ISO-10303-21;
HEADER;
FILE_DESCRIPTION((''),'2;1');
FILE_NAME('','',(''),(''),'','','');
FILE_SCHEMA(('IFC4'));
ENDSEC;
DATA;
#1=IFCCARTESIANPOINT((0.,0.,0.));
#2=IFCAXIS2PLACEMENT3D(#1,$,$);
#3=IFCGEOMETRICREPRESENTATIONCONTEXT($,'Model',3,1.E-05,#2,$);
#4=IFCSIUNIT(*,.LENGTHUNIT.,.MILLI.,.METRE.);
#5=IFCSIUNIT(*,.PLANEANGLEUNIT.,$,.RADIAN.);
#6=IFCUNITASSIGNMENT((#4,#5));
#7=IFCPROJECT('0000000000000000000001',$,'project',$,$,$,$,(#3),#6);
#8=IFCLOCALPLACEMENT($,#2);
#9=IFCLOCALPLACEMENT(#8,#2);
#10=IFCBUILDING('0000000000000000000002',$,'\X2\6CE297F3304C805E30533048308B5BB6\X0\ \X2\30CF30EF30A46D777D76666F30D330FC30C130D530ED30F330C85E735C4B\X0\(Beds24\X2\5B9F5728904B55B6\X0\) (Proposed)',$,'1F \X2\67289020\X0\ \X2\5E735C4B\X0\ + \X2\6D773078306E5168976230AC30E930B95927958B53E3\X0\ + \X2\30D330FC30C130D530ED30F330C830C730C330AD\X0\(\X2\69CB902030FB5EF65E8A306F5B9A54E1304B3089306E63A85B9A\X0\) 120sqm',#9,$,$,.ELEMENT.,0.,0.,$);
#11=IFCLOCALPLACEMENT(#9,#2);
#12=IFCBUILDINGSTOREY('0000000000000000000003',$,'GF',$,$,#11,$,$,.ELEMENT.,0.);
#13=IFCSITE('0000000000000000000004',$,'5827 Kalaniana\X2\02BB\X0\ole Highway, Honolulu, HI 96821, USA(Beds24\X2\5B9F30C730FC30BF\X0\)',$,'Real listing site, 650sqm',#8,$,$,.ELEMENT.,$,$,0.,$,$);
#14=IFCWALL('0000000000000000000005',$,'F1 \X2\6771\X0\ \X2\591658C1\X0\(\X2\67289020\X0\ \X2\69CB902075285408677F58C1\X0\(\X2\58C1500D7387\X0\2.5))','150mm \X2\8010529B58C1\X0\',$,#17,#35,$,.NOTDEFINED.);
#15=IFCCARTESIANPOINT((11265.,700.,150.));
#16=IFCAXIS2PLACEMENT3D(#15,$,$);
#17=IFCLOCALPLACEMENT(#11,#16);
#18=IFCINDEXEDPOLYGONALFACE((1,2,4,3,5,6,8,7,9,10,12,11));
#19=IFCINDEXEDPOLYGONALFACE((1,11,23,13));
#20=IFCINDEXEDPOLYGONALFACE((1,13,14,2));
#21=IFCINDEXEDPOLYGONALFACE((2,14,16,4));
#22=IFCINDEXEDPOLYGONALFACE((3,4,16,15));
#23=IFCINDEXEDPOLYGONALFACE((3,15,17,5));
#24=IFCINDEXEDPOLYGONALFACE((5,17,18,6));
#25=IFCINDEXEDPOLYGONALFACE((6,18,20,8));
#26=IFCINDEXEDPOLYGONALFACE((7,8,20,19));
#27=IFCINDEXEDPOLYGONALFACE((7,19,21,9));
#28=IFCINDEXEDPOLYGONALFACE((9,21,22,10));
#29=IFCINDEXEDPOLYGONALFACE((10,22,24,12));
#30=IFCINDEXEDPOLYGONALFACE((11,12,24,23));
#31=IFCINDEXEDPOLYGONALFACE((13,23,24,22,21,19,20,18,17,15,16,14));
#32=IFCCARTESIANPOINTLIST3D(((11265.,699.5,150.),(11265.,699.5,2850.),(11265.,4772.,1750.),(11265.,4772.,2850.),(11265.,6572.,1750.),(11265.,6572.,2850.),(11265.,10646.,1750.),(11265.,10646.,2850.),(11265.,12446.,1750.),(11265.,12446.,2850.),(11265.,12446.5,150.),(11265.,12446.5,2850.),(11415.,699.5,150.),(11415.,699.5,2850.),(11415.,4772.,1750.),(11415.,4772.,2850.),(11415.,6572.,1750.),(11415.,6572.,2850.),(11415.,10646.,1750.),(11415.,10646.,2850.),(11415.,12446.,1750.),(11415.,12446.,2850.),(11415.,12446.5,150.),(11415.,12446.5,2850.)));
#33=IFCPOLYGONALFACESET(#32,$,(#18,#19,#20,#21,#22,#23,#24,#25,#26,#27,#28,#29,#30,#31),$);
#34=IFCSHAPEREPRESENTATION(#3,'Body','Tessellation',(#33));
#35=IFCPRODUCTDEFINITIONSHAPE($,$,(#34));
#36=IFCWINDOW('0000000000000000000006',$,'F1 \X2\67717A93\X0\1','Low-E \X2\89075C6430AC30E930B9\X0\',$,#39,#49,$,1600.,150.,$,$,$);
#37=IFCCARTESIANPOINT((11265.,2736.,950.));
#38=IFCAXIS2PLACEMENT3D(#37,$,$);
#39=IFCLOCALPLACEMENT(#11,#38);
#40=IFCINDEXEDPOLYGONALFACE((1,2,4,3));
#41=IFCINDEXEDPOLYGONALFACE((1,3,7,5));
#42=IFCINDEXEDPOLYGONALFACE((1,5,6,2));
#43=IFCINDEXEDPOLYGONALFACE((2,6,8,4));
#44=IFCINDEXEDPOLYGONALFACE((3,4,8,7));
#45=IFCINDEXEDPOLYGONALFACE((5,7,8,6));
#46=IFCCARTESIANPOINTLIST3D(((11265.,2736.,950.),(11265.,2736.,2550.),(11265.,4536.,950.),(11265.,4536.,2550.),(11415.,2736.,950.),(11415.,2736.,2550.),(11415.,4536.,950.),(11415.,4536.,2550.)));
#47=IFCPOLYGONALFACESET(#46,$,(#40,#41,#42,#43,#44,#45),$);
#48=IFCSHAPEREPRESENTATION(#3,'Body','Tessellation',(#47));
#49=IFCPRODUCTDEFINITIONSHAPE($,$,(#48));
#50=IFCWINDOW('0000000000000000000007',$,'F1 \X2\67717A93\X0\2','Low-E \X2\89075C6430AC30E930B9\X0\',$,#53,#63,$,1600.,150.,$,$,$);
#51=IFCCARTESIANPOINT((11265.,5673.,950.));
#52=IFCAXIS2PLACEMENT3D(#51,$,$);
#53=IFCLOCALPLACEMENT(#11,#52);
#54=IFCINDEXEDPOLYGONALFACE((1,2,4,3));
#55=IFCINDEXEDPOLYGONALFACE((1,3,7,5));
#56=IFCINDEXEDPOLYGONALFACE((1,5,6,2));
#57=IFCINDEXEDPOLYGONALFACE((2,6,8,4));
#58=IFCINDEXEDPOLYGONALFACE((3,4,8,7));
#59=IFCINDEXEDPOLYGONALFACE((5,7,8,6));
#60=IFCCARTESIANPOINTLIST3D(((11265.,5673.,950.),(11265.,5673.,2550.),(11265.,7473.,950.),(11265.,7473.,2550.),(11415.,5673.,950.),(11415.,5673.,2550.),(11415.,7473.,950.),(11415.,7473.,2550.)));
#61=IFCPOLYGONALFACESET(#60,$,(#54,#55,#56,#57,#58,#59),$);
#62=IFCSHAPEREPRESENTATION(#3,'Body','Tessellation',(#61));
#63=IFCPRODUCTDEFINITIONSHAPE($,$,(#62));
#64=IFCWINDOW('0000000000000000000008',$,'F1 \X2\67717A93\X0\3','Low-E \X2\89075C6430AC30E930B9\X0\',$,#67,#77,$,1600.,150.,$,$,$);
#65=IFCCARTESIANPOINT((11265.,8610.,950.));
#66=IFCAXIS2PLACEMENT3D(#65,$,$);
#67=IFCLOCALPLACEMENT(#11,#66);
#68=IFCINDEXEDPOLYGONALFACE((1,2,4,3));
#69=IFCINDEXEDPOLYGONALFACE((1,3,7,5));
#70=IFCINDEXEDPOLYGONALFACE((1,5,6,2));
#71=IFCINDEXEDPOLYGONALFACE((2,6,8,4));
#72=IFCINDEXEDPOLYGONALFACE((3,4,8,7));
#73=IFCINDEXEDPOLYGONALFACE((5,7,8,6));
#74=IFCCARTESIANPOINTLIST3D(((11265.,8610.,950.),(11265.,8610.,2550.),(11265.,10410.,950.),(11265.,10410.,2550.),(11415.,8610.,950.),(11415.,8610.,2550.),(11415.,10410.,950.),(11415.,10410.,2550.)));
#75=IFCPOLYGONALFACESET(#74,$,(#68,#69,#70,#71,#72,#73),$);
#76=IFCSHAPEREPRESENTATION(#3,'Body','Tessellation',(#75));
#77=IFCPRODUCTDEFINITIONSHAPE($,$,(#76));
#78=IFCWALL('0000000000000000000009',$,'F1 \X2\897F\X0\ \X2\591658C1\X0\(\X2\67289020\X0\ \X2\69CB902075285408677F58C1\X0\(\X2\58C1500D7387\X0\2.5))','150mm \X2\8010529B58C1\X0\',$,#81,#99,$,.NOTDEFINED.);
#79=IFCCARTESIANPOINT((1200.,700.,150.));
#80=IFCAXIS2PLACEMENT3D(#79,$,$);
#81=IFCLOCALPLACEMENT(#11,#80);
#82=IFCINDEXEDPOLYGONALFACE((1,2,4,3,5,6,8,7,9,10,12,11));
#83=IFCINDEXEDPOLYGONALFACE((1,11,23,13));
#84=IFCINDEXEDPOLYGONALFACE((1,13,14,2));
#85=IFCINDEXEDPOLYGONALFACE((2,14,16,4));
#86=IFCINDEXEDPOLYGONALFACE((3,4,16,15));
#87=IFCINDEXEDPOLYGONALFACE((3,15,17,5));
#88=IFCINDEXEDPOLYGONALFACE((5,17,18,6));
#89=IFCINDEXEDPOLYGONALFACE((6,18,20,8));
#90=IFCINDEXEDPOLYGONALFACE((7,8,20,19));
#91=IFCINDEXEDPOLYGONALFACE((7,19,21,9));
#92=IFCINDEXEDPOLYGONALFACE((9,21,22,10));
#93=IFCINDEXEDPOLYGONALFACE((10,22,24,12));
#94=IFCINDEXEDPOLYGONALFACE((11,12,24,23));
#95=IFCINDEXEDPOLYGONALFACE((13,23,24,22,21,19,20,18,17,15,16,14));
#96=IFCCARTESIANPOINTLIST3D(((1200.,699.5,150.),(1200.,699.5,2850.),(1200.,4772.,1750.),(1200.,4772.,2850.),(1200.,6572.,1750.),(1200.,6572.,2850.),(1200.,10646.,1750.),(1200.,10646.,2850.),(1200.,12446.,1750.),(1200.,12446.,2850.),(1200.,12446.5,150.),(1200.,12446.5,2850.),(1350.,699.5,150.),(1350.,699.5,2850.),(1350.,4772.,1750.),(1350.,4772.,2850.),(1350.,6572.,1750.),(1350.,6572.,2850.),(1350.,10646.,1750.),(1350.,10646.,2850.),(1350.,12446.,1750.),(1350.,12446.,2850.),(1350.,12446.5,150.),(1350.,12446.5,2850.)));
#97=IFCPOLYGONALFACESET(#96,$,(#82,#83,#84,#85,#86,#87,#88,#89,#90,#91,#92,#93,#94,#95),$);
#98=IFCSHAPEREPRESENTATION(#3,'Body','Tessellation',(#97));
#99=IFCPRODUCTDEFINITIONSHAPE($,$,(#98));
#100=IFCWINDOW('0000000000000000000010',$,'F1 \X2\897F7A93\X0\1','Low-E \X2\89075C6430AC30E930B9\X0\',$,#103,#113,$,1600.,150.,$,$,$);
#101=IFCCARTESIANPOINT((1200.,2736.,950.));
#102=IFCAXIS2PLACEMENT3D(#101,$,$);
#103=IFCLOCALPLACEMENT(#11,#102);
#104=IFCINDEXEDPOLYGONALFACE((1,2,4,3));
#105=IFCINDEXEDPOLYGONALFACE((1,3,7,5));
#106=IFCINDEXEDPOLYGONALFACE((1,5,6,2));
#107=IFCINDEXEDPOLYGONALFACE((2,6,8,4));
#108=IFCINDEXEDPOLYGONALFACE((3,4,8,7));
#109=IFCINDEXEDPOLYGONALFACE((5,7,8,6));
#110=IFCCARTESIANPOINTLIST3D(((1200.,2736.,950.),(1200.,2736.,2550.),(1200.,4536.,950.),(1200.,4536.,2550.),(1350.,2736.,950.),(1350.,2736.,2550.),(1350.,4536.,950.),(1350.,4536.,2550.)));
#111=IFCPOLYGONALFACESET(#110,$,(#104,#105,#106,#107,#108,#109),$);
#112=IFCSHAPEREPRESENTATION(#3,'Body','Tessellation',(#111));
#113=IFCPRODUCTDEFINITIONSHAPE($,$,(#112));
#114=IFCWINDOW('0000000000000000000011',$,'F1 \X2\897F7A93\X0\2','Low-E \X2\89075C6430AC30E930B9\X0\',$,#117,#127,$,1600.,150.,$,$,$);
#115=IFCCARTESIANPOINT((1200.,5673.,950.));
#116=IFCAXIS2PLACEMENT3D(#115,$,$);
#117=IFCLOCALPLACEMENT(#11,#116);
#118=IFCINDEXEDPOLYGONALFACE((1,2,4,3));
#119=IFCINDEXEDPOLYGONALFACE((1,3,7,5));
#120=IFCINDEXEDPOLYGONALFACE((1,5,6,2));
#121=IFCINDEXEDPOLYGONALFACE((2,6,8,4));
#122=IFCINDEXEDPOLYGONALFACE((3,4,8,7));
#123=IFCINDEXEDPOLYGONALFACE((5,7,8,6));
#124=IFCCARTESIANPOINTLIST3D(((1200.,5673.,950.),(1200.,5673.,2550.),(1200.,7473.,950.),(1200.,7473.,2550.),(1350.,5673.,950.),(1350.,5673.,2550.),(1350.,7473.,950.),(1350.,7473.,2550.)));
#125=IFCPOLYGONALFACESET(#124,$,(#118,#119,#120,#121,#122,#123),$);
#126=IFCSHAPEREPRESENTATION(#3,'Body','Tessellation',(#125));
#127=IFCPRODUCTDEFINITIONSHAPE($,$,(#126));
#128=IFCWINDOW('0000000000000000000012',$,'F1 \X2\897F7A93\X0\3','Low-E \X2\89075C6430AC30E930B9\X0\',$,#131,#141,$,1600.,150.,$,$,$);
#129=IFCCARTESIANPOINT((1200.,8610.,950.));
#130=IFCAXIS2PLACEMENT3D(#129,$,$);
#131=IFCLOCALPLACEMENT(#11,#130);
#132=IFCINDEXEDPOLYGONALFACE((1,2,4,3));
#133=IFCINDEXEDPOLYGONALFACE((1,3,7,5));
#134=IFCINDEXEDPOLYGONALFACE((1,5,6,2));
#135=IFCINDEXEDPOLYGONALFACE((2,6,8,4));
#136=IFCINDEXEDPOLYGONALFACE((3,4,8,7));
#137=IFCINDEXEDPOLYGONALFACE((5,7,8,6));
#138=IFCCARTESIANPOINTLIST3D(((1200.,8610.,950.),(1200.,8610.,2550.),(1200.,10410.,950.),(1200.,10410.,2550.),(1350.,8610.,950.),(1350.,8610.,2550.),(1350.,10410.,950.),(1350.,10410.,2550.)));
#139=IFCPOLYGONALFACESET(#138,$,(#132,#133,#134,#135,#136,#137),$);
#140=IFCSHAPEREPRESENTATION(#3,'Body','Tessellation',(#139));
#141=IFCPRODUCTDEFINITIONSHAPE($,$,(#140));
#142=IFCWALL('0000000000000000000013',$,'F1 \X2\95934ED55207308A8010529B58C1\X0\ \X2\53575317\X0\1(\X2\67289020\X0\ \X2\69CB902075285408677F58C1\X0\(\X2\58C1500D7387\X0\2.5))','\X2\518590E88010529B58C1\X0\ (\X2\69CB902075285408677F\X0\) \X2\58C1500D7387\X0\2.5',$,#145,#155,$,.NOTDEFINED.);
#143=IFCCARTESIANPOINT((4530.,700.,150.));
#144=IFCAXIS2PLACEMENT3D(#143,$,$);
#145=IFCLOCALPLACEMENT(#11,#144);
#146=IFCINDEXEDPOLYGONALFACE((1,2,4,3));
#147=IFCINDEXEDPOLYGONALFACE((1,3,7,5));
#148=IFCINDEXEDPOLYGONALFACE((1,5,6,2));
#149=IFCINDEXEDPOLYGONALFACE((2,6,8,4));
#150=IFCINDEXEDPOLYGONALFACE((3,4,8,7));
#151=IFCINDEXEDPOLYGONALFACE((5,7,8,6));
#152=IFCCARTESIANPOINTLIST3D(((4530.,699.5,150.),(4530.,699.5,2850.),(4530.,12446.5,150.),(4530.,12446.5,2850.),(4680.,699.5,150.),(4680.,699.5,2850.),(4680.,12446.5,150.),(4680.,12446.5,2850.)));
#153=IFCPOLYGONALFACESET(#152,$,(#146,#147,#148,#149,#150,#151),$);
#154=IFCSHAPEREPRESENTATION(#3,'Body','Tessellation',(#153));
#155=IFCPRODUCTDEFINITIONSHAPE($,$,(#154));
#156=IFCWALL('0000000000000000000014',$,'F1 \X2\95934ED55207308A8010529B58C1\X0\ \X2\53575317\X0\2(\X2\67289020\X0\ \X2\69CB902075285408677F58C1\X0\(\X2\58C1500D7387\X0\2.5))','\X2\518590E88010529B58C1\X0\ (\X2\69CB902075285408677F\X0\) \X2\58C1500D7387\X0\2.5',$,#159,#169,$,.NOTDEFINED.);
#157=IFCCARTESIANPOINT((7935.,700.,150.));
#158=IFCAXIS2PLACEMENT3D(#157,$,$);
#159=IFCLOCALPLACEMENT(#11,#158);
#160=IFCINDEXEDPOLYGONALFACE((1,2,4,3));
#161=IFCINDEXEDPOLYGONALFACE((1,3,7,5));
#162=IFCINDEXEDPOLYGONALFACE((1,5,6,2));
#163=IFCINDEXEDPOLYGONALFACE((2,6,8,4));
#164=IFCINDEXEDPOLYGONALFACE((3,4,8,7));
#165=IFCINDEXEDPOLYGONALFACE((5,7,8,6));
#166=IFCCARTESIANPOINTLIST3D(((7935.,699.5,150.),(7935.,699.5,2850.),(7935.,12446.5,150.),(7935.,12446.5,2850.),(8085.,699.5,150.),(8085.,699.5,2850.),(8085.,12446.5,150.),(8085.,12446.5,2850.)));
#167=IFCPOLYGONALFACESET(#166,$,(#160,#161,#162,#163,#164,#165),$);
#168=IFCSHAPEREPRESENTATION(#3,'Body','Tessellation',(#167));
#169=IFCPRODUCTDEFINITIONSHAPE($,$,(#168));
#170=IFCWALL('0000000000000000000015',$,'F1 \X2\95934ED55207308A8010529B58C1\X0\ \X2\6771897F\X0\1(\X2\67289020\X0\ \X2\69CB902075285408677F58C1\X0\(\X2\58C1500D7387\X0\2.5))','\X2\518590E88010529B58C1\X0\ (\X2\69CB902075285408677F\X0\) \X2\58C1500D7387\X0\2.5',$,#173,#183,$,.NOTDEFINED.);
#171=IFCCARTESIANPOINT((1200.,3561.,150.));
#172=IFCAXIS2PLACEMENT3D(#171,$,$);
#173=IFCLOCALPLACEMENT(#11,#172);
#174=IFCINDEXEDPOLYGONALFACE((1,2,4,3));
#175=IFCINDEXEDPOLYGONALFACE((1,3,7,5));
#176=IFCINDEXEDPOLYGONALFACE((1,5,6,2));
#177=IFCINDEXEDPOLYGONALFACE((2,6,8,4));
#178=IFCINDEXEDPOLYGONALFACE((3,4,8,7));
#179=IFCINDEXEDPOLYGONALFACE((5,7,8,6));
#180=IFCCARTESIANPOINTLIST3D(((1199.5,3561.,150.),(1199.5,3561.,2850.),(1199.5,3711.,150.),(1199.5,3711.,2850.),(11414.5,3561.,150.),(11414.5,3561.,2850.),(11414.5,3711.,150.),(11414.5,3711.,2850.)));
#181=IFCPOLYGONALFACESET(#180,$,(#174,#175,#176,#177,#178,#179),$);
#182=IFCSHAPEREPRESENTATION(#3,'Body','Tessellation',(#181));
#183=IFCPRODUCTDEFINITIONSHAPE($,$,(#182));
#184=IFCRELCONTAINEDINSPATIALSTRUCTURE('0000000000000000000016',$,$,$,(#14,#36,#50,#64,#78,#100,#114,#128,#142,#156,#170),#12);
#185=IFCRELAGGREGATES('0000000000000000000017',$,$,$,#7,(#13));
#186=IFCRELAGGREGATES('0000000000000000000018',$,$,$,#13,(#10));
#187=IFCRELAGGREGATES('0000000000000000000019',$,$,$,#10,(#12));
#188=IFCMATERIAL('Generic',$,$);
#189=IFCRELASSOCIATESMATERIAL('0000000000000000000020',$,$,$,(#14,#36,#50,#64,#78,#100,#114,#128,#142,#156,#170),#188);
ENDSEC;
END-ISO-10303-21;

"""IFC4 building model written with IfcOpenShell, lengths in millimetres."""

from ifc_helpers import new_model, si_unit, frame, frame_2d, origin, place, context, project, spatial, rectangle, extrude, material, element, fill, save


model = new_model("IFC4")

# Units and contexts
model_context = context("Model", 3, precision=1e-05, world=origin())
ifc_project = project(units=[si_unit("LENGTHUNIT", "METRE", prefix="MILLI"), si_unit("PLANEANGLEUNIT", "RADIAN")], contexts=[model_context])

# Site, building, storey
site_placement = place(None, origin())
site = spatial("IfcSite", under=ifc_project, at=site_placement, Name="5827 Kalanianaʻole Highway, Honolulu, HI 96821, USA(Beds24実データ)", ObjectType="Real listing site, 650sqm", CompositionType="ELEMENT", RefElevation=0.0)
building_placement = place(site_placement, origin())
building = spatial("IfcBuilding", under=site, at=building_placement, Name="波音が聞こえる家 ハワイ海絶景ビーチフロント平屋(Beds24実在運営) (Proposed)", ObjectType="1F 木造 平屋 + 海への全面ガラス大開口 + ビーチフロントデッキ(構造・延床は定員からの推定) 120sqm", CompositionType="ELEMENT", ElevationOfRefHeight=0.0, ElevationOfTerrain=0.0)
storey_placement = place(building_placement, origin())
storey = spatial("IfcBuildingStorey", under=building, at=storey_placement, Name="GF", CompositionType="ELEMENT", Elevation=0.0)

# Shared definitions
ifc_material_1 = material(Name="Generic")

# Walls, openings, windows
wall_1_placement = place(storey_placement, frame((11265.0, 700.0, 150.0)))
wall_1 = element("IfcWall", 1, at=wall_1_placement, inside=storey, material=ifc_material_1, Name="F1 東 外壁(木造 構造用合板壁(壁倍率2.5))", Description="150mm 耐力壁", PredefinedType="NOTDEFINED", context=model_context, shape_type="SweptSolid", body=[
    extrude(rectangle(XDim=150.0, YDim=11747.0, at=frame_2d((75.0, 5873.0))), frame((11265.0, 700.0, 150.0)), (0.0, 0.0, 1.0), 2700.0),
])
opening_1_placement = place(storey_placement, frame((11265.0, 2736.0, 950.0)))
opening_1 = element("IfcOpeningElement", 2, at=opening_1_placement, cuts=wall_1, PredefinedType="NOTDEFINED", context=model_context, shape_type="SweptSolid", body=[
    extrude(rectangle(XDim=150.0, YDim=1800.0, at=frame_2d((75.0, 900.0))), frame((11265.0, 2736.0, 950.0)), (0.0, 0.0, 1.0), 1600.0),
])
opening_2_placement = place(storey_placement, frame((11265.0, 5673.0, 950.0)))
opening_2 = element("IfcOpeningElement", 3, at=opening_2_placement, cuts=wall_1, PredefinedType="NOTDEFINED", context=model_context, shape_type="SweptSolid", body=[
    extrude(rectangle(XDim=150.0, YDim=1800.0, at=frame_2d((75.0, 900.0))), frame((11265.0, 5673.0, 950.0)), (0.0, 0.0, 1.0), 1600.0),
])
opening_3_placement = place(storey_placement, frame((11265.0, 8610.0, 950.0)))
opening_3 = element("IfcOpeningElement", 4, at=opening_3_placement, cuts=wall_1, PredefinedType="NOTDEFINED", context=model_context, shape_type="SweptSolid", body=[
    extrude(rectangle(XDim=150.0, YDim=1800.0, at=frame_2d((75.0, 900.0))), frame((11265.0, 8610.0, 950.0)), (0.0, 0.0, 1.0), 1600.0),
])
window_1_placement = place(storey_placement, frame((11265.0, 2736.0, 950.0)))
window_1 = element("IfcWindow", 5, at=window_1_placement, inside=storey, material=ifc_material_1, Name="F1 東窓1", Description="Low-E 複層ガラス", OverallHeight=1600.0, OverallWidth=150.0, context=model_context, shape_type="SweptSolid", body=[
    extrude(rectangle(XDim=150.0, YDim=1800.0, at=frame_2d((75.0, 900.0))), frame((11265.0, 2736.0, 950.0)), (0.0, 0.0, 1.0), 1600.0),
])
fill(opening_1, window_1)
window_2_placement = place(storey_placement, frame((11265.0, 5673.0, 950.0)))
window_2 = element("IfcWindow", 6, at=window_2_placement, inside=storey, material=ifc_material_1, Name="F1 東窓2", Description="Low-E 複層ガラス", OverallHeight=1600.0, OverallWidth=150.0, context=model_context, shape_type="SweptSolid", body=[
    extrude(rectangle(XDim=150.0, YDim=1800.0, at=frame_2d((75.0, 900.0))), frame((11265.0, 5673.0, 950.0)), (0.0, 0.0, 1.0), 1600.0),
])
fill(opening_2, window_2)
window_3_placement = place(storey_placement, frame((11265.0, 8610.0, 950.0)))
window_3 = element("IfcWindow", 7, at=window_3_placement, inside=storey, material=ifc_material_1, Name="F1 東窓3", Description="Low-E 複層ガラス", OverallHeight=1600.0, OverallWidth=150.0, context=model_context, shape_type="SweptSolid", body=[
    extrude(rectangle(XDim=150.0, YDim=1800.0, at=frame_2d((75.0, 900.0))), frame((11265.0, 8610.0, 950.0)), (0.0, 0.0, 1.0), 1600.0),
])
fill(opening_3, window_3)
wall_2_placement = place(storey_placement, frame((1200.0, 700.0, 150.0)))
wall_2 = element("IfcWall", 8, at=wall_2_placement, inside=storey, material=ifc_material_1, Name="F1 西 外壁(木造 構造用合板壁(壁倍率2.5))", Description="150mm 耐力壁", PredefinedType="NOTDEFINED", context=model_context, shape_type="SweptSolid", body=[
    extrude(rectangle(XDim=150.0, YDim=11747.0, at=frame_2d((75.0, 5873.0))), frame((1200.0, 700.0, 150.0)), (0.0, 0.0, 1.0), 2700.0),
])
opening_4_placement = place(storey_placement, frame((1200.0, 2736.0, 950.0)))
opening_4 = element("IfcOpeningElement", 9, at=opening_4_placement, cuts=wall_2, PredefinedType="NOTDEFINED", context=model_context, shape_type="SweptSolid", body=[
    extrude(rectangle(XDim=150.0, YDim=1800.0, at=frame_2d((75.0, 900.0))), frame((1200.0, 2736.0, 950.0)), (0.0, 0.0, 1.0), 1600.0),
])
opening_5_placement = place(storey_placement, frame((1200.0, 5673.0, 950.0)))
opening_5 = element("IfcOpeningElement", 10, at=opening_5_placement, cuts=wall_2, PredefinedType="NOTDEFINED", context=model_context, shape_type="SweptSolid", body=[
    extrude(rectangle(XDim=150.0, YDim=1800.0, at=frame_2d((75.0, 900.0))), frame((1200.0, 5673.0, 950.0)), (0.0, 0.0, 1.0), 1600.0),
])
opening_6_placement = place(storey_placement, frame((1200.0, 8610.0, 950.0)))
opening_6 = element("IfcOpeningElement", 11, at=opening_6_placement, cuts=wall_2, PredefinedType="NOTDEFINED", context=model_context, shape_type="SweptSolid", body=[
    extrude(rectangle(XDim=150.0, YDim=1800.0, at=frame_2d((75.0, 900.0))), frame((1200.0, 8610.0, 950.0)), (0.0, 0.0, 1.0), 1600.0),
])
window_4_placement = place(storey_placement, frame((1200.0, 2736.0, 950.0)))
window_4 = element("IfcWindow", 12, at=window_4_placement, inside=storey, material=ifc_material_1, Name="F1 西窓1", Description="Low-E 複層ガラス", OverallHeight=1600.0, OverallWidth=150.0, context=model_context, shape_type="SweptSolid", body=[
    extrude(rectangle(XDim=150.0, YDim=1800.0, at=frame_2d((75.0, 900.0))), frame((1200.0, 2736.0, 950.0)), (0.0, 0.0, 1.0), 1600.0),
])
fill(opening_4, window_4)
window_5_placement = place(storey_placement, frame((1200.0, 5673.0, 950.0)))
window_5 = element("IfcWindow", 13, at=window_5_placement, inside=storey, material=ifc_material_1, Name="F1 西窓2", Description="Low-E 複層ガラス", OverallHeight=1600.0, OverallWidth=150.0, context=model_context, shape_type="SweptSolid", body=[
    extrude(rectangle(XDim=150.0, YDim=1800.0, at=frame_2d((75.0, 900.0))), frame((1200.0, 5673.0, 950.0)), (0.0, 0.0, 1.0), 1600.0),
])
fill(opening_5, window_5)
window_6_placement = place(storey_placement, frame((1200.0, 8610.0, 950.0)))
window_6 = element("IfcWindow", 14, at=window_6_placement, inside=storey, material=ifc_material_1, Name="F1 西窓3", Description="Low-E 複層ガラス", OverallHeight=1600.0, OverallWidth=150.0, context=model_context, shape_type="SweptSolid", body=[
    extrude(rectangle(XDim=150.0, YDim=1800.0, at=frame_2d((75.0, 900.0))), frame((1200.0, 8610.0, 950.0)), (0.0, 0.0, 1.0), 1600.0),
])
fill(opening_6, window_6)

# Walls
wall_3_placement = place(storey_placement, frame((4530.0, 700.0, 150.0)))
element("IfcWall", 15, at=wall_3_placement, inside=storey, material=ifc_material_1, Name="F1 間仕切り耐力壁 南北1(木造 構造用合板壁(壁倍率2.5))", Description="内部耐力壁 (構造用合板) 壁倍率2.5", PredefinedType="NOTDEFINED", context=model_context, shape_type="SweptSolid", body=[
    extrude(rectangle(XDim=150.0, YDim=11747.0, at=frame_2d((75.0, 5873.0))), frame((4530.0, 700.0, 150.0)), (0.0, 0.0, 1.0), 2700.0),
])
wall_4_placement = place(storey_placement, frame((7935.0, 700.0, 150.0)))
element("IfcWall", 16, at=wall_4_placement, inside=storey, material=ifc_material_1, Name="F1 間仕切り耐力壁 南北2(木造 構造用合板壁(壁倍率2.5))", Description="内部耐力壁 (構造用合板) 壁倍率2.5", PredefinedType="NOTDEFINED", context=model_context, shape_type="SweptSolid", body=[
    extrude(rectangle(XDim=150.0, YDim=11747.0, at=frame_2d((75.0, 5873.0))), frame((7935.0, 700.0, 150.0)), (0.0, 0.0, 1.0), 2700.0),
])
wall_5_placement = place(storey_placement, frame((1200.0, 3561.0, 150.0)))
element("IfcWall", 17, at=wall_5_placement, inside=storey, material=ifc_material_1, Name="F1 間仕切り耐力壁 東西1(木造 構造用合板壁(壁倍率2.5))", Description="内部耐力壁 (構造用合板) 壁倍率2.5", PredefinedType="NOTDEFINED", context=model_context, shape_type="SweptSolid", body=[
    extrude(rectangle(XDim=10215.0, YDim=150.0, at=frame_2d((5107.0, 75.0))), frame((1200.0, 3561.0, 150.0)), (0.0, 0.0, 1.0), 2700.0),
])

save(model, "model.ifc")
